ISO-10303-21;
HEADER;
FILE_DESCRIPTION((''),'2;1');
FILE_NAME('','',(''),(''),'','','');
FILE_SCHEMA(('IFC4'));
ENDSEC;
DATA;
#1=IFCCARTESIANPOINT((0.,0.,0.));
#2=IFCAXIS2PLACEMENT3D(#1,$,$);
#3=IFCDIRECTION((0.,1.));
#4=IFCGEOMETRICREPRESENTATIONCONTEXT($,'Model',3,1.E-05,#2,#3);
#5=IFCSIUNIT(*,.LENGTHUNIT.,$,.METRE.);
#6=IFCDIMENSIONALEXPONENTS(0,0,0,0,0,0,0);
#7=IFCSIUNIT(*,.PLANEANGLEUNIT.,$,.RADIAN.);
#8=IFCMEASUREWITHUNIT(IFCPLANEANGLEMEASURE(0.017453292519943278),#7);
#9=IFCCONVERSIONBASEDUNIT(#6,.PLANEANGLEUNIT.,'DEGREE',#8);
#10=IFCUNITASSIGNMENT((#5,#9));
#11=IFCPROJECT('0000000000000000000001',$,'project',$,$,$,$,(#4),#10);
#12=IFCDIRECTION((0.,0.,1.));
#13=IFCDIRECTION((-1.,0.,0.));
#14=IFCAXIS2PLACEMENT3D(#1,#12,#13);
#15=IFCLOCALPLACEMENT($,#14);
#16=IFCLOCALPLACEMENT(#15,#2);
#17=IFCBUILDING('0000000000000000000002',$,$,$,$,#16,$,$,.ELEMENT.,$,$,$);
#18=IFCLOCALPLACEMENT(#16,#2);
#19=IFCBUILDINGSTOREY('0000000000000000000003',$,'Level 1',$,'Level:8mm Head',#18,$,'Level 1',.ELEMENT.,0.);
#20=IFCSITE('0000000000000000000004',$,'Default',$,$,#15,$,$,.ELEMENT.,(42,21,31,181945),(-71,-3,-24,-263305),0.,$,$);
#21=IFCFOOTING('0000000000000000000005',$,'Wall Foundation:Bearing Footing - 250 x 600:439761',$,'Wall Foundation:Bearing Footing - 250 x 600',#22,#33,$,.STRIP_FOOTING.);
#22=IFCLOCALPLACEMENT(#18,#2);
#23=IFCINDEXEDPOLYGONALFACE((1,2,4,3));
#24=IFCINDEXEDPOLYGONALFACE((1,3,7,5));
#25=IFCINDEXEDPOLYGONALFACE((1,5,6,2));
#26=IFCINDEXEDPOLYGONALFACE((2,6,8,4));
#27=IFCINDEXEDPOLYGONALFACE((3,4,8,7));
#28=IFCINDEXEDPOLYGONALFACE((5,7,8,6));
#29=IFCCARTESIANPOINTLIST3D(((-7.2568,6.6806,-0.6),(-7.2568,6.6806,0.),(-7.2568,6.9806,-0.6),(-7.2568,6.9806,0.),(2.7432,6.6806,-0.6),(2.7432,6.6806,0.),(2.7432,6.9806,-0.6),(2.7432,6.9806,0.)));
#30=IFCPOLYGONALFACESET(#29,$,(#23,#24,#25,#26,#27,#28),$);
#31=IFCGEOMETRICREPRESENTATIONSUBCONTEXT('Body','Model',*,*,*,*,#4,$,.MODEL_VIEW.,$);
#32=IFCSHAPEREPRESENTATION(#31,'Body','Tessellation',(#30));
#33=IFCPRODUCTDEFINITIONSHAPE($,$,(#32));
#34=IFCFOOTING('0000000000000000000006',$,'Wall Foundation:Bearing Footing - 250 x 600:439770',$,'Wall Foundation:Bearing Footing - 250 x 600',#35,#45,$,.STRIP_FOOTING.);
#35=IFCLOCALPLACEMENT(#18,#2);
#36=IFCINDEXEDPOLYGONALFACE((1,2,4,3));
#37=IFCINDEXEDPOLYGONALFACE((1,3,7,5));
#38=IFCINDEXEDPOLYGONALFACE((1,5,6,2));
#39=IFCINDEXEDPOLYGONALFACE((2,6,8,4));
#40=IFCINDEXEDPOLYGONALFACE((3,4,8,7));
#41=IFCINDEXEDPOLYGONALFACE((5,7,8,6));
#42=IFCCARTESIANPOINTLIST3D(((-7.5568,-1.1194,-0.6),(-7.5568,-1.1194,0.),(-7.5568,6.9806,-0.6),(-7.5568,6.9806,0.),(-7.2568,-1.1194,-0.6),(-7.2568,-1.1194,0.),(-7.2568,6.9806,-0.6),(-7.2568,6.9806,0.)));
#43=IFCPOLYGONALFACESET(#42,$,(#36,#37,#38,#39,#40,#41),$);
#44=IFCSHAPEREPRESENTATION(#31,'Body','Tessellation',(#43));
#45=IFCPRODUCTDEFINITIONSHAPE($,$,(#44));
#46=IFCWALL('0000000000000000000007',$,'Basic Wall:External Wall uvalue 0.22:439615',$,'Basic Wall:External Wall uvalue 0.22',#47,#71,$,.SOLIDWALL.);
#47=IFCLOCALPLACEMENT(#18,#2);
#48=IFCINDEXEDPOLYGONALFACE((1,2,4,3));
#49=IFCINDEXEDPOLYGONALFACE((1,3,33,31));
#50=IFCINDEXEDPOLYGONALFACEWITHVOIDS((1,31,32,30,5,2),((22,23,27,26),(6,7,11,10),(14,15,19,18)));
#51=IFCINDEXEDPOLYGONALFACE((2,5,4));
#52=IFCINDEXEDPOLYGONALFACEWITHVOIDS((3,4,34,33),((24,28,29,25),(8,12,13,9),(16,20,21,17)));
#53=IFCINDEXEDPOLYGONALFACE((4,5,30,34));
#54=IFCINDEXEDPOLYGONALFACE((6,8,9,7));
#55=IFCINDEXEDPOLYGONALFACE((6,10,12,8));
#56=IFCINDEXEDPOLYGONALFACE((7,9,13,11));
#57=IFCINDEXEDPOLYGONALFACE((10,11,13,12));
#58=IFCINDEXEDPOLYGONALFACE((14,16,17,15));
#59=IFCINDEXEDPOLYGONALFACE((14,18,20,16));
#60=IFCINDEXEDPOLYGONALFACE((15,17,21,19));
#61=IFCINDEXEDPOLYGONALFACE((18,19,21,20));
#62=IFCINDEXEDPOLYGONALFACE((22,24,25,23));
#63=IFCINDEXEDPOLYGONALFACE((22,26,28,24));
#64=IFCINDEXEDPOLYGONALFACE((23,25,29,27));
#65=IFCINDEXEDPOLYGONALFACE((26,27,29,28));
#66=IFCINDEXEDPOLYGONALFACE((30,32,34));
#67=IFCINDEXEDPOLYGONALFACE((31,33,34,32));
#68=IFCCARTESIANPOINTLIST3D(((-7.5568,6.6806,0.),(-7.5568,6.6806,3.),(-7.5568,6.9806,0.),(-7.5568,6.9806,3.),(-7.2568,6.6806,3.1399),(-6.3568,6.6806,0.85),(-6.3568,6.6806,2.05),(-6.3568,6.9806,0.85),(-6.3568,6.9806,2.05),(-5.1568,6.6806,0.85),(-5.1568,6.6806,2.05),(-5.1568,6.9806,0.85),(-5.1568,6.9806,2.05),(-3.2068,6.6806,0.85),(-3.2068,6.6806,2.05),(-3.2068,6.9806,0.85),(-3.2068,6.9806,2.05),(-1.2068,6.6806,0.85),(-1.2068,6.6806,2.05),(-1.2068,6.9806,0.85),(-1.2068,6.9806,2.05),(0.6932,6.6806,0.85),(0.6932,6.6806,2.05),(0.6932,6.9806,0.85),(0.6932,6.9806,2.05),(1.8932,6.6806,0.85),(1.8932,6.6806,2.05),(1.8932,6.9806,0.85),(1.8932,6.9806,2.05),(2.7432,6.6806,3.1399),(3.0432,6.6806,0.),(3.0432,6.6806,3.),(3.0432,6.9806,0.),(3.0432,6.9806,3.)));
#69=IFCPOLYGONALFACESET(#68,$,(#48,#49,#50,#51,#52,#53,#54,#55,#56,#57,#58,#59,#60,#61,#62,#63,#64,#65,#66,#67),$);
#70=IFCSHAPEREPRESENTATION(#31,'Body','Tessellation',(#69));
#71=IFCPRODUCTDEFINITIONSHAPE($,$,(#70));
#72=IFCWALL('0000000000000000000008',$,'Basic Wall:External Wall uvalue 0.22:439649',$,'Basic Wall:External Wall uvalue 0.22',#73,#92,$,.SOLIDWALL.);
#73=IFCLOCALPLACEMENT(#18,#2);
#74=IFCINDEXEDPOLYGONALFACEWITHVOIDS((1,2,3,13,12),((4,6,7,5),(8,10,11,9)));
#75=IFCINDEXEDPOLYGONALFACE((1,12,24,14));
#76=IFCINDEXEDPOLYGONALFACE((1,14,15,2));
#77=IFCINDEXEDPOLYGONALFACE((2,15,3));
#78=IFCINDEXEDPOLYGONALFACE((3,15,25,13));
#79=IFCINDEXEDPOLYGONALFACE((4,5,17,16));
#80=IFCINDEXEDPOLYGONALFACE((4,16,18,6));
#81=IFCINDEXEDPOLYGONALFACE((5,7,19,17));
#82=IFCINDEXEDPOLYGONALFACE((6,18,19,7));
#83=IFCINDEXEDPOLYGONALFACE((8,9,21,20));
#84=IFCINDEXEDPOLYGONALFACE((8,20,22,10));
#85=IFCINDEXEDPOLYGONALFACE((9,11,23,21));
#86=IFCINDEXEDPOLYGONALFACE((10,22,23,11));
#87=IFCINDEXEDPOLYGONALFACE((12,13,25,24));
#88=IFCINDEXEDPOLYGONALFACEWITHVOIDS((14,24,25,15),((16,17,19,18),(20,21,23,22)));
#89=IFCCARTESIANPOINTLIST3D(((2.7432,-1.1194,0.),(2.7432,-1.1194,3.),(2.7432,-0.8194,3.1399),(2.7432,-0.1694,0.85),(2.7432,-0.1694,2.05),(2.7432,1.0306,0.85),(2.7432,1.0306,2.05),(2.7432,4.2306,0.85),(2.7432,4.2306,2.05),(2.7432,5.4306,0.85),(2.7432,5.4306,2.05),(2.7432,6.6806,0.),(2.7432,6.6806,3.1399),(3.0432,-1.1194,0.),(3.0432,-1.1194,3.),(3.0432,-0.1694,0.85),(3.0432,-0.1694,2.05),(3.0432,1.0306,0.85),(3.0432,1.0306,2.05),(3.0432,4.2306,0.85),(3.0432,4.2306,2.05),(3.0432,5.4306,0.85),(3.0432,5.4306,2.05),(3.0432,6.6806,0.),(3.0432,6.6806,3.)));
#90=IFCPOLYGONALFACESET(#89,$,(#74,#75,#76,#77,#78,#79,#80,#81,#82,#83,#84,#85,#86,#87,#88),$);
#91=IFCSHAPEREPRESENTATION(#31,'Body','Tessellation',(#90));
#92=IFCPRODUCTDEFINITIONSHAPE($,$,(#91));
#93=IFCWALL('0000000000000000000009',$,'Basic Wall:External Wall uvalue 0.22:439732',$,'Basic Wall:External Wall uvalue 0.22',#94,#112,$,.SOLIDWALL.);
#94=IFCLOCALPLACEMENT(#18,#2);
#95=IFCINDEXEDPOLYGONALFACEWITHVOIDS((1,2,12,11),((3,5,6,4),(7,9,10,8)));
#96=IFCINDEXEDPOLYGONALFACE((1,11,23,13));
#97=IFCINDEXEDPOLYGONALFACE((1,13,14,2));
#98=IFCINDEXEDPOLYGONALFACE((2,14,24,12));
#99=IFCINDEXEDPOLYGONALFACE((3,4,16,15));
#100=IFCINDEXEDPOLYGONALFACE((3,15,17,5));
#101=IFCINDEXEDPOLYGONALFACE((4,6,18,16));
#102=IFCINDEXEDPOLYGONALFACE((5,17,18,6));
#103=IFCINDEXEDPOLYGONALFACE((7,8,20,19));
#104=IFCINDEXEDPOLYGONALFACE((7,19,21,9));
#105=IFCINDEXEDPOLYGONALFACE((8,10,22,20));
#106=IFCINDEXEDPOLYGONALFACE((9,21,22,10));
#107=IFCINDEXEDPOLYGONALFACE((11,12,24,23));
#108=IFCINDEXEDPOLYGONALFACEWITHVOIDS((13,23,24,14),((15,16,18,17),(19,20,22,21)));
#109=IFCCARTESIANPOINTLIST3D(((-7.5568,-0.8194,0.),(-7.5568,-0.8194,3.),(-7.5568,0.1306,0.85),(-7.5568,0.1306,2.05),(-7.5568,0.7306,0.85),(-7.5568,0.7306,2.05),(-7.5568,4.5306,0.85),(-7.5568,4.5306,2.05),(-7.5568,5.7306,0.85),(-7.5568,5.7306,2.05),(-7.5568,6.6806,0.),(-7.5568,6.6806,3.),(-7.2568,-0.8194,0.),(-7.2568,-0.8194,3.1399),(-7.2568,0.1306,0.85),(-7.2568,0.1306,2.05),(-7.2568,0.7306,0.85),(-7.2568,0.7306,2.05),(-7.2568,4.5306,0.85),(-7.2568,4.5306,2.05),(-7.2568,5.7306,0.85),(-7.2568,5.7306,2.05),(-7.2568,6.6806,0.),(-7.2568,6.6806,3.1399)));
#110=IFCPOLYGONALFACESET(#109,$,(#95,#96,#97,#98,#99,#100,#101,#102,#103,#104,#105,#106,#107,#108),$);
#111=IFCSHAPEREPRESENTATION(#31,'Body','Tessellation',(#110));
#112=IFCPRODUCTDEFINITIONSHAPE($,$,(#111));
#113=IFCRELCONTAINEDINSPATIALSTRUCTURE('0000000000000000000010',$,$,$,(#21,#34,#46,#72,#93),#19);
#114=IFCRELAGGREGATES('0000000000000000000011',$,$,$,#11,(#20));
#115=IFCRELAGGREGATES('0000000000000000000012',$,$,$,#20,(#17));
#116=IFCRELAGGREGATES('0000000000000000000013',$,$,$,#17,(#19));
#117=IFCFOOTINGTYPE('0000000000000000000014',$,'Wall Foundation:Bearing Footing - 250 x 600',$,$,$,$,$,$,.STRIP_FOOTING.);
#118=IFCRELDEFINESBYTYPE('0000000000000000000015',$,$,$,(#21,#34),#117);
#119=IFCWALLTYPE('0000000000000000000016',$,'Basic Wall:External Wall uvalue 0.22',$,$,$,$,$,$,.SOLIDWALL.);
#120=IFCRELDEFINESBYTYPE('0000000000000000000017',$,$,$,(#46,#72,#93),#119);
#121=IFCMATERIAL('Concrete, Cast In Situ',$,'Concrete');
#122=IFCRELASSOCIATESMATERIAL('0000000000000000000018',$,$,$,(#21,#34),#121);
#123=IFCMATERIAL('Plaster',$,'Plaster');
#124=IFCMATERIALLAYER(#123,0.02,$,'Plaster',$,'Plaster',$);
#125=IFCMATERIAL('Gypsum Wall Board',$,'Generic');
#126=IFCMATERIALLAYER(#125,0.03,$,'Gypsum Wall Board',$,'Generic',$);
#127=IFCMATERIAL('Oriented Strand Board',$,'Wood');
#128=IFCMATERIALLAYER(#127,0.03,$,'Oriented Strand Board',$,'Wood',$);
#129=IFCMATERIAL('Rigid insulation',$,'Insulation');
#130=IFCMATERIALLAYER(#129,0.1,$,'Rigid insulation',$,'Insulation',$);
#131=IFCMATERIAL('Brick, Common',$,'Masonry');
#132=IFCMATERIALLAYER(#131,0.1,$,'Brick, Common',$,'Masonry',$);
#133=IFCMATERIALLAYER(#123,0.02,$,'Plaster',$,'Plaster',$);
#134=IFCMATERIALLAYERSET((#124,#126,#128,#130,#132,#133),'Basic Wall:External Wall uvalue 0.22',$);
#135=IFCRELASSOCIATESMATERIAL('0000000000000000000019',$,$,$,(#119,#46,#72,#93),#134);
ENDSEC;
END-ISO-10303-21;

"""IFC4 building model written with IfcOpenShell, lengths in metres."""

from ifc_helpers import new_model, entity, si_unit, converted_unit, direction, frame, frame_2d, origin, place, context, subcontext, project, spatial, polyline, rectangle, extrude, clip, bounded_halfspace, material, layer, layer_set, layer_usage, type_object, element, save


model = new_model("IFC4")

# Units and contexts
model_context = context("Model", 3, precision=1e-05, world=origin(), true_north=direction((0.0, 1.0)))
body_context = subcontext(model_context, "Body", "Model", "MODEL_VIEW")
ifc_project = project(units=[si_unit("LENGTHUNIT", "METRE"), converted_unit("PLANEANGLEUNIT", "DEGREE", entity("IfcPlaneAngleMeasure", 0.017453292519943278), si_unit("PLANEANGLEUNIT", "RADIAN"), dimensions=[0, 0, 0, 0, 0, 0, 0])], contexts=[model_context])

# Site, building, storey
site_placement = place(None, frame((0.0, 0.0, 0.0), z_axis=(0.0, 0.0, 1.0), x_axis=(-1.0, 0.0, 0.0)))
site = spatial("IfcSite", under=ifc_project, at=site_placement, Name="Default", CompositionType="ELEMENT", RefLatitude=(42, 21, 31, 181945), RefLongitude=(-71, -3, -24, -263305), RefElevation=0.0)
building_placement = place(site_placement, origin())
building = spatial("IfcBuilding", under=site, at=building_placement, CompositionType="ELEMENT")
storey_placement = place(building_placement, origin())
storey = spatial("IfcBuildingStorey", under=building, at=storey_placement, Name="Level 1", ObjectType="Level:8mm Head", LongName="Level 1", CompositionType="ELEMENT", Elevation=0.0)

# Footings
ifc_material_1 = material(Name="Concrete, Cast In Situ", Category="Concrete")
footing_type = type_object("IfcFootingType", Name="Wall Foundation:Bearing Footing - 250 x 600", PredefinedType="STRIP_FOOTING")
footing_1_placement = place(storey_placement, frame((-7.2568, 6.6806, -0.6)))
element("IfcFooting", 1, at=footing_1_placement, inside=storey, type_object=footing_type, material=ifc_material_1, Name="Wall Foundation:Bearing Footing - 250 x 600:439761", ObjectType="Wall Foundation:Bearing Footing - 250 x 600", PredefinedType="STRIP_FOOTING", context=body_context, shape_type="SweptSolid", body=[
    extrude(rectangle(XDim=10.0, YDim=0.3, at=frame_2d((0.0, 0.0), x_axis=(1.0, 0.0))), frame((5.0, 0.15, 0.0)), (0.0, 0.0, 1.0), 0.6),
])
footing_2_placement = place(storey_placement, frame((-7.5568, -1.1194, -0.6)))
element("IfcFooting", 2, at=footing_2_placement, inside=storey, type_object=footing_type, material=ifc_material_1, Name="Wall Foundation:Bearing Footing - 250 x 600:439770", ObjectType="Wall Foundation:Bearing Footing - 250 x 600", PredefinedType="STRIP_FOOTING", context=body_context, shape_type="SweptSolid", body=[
    extrude(rectangle(XDim=8.1, YDim=0.3, at=frame_2d((0.0, 0.05), x_axis=(1.0, 0.0))), frame((0.2, 4.05, 0.0), z_axis=(0.0, 0.0, 1.0), x_axis=(0.0, 1.0, 0.0)), (0.0, 0.0, 1.0), 0.6),
])

# Walls, openings
ifc_material_2 = material(Name="Plaster", Category="Plaster")
ifc_layer_1 = layer(ifc_material_2, 0.02, Name="Plaster", Category="Plaster")
ifc_material_3 = material(Name="Gypsum Wall Board", Category="Generic")
ifc_layer_2 = layer(ifc_material_3, 0.03, Name="Gypsum Wall Board", Category="Generic")
ifc_material_4 = material(Name="Oriented Strand Board", Category="Wood")
ifc_layer_3 = layer(ifc_material_4, 0.03, Name="Oriented Strand Board", Category="Wood")
ifc_material_5 = material(Name="Rigid insulation", Category="Insulation")
ifc_layer_4 = layer(ifc_material_5, 0.1, Name="Rigid insulation", Category="Insulation")
ifc_material_6 = material(Name="Brick, Common", Category="Masonry")
ifc_layer_5 = layer(ifc_material_6, 0.1, Name="Brick, Common", Category="Masonry")
ifc_layer_6 = layer(ifc_material_2, 0.02, Name="Plaster", Category="Plaster")
ifc_layer_set_1 = layer_set([ifc_layer_1, ifc_layer_2, ifc_layer_3, ifc_layer_4, ifc_layer_5, ifc_layer_6], Name="Basic Wall:External Wall uvalue 0.22")
ifc_layer_usage_1 = layer_usage(ifc_layer_set_1, "AXIS2", "NEGATIVE", 0.15)
wall_type_1 = type_object("IfcWallType", Name="Basic Wall:External Wall uvalue 0.22", PredefinedType="SOLIDWALL", material=ifc_layer_set_1)
wall_1_placement = place(storey_placement, frame((-7.5568, 6.8306, 0.0)))
wall_1 = element("IfcWall", 3, at=wall_1_placement, inside=storey, type_object=wall_type_1, material=ifc_layer_usage_1, Name="Basic Wall:External Wall uvalue 0.22:439615", ObjectType="Basic Wall:External Wall uvalue 0.22", PredefinedType="SOLIDWALL", context=body_context, shape_type="Clipping", body=[
    clip(clip(clip(extrude(rectangle(XDim=10.6, YDim=0.3, at=frame_2d((5.3, 0.0), x_axis=(-1.0, 0.0))), origin(), (0.0, 0.0, 1.0), 3.1399), bounded_halfspace(frame((0.3, -0.15, 3.1399), z_axis=(0.0, 0.422618, 0.906308), x_axis=(-1.0, 0.0, 0.0)), False, frame((0.3, -0.15, 3.1399)), polyline([(0.0, 0.0), (10.0, 0.0), (10.3, 0.3), (-0.3, 0.3), (0.0, 0.0)]))), bounded_halfspace(frame((0.0, -0.15, 3.0), z_axis=(-0.422618, 0.0, 0.906308), x_axis=(0.0, -1.0, 0.0)), False, frame((0.0, -0.15, 3.0)), polyline([(0.0, 0.0), (0.3, 0.0), (0.0, 0.3), (0.0, 0.0)]))), bounded_halfspace(frame((10.3, -0.15, 3.1399), z_axis=(0.422618, 0.0, 0.906308), x_axis=(0.0, 1.0, 0.0)), False, frame((10.3, -0.15, 3.1399)), polyline([(0.0, 0.0), (0.3, 0.0), (0.3, 0.3), (0.0, 0.0)]))),
])
opening_1_placement = place(wall_1_placement, frame((1.2, -0.15, 0.85)))
element("IfcOpeningElement", 4, at=opening_1_placement, cuts=wall_1, PredefinedType="OPENING", context=body_context, shape_type="SweptSolid", body=[
    extrude(rectangle(XDim=1.2, YDim=1.2, at=frame_2d((0.6, 0.6), x_axis=(1.0, 0.0))), frame((0.0, 0.0, 0.0), z_axis=(0.0, 1.0, 0.0), x_axis=(0.0, 0.0, 1.0)), (0.0, 0.0, 1.0), 0.3),
])
opening_2_placement = place(wall_1_placement, frame((8.25, -0.15, 0.85)))
element("IfcOpeningElement", 5, at=opening_2_placement, cuts=wall_1, PredefinedType="OPENING", context=body_context, shape_type="SweptSolid", body=[
    extrude(rectangle(XDim=1.2, YDim=1.2, at=frame_2d((0.6, 0.6), x_axis=(1.0, 0.0))), frame((0.0, 0.0, 0.0), z_axis=(0.0, 1.0, 0.0), x_axis=(0.0, 0.0, 1.0)), (0.0, 0.0, 1.0), 0.3),
])
opening_3_placement = place(wall_1_placement, frame((4.35, -0.15, 0.85)))
element("IfcOpeningElement", 6, at=opening_3_placement, cuts=wall_1, PredefinedType="OPENING", context=body_context, shape_type="SweptSolid", body=[
    extrude(rectangle(XDim=1.2, YDim=2.0, at=frame_2d((0.6, 1.0), x_axis=(1.0, 0.0))), frame((0.0, 0.0, 0.0), z_axis=(0.0, 1.0, 0.0), x_axis=(0.0, 0.0, 1.0)), (0.0, 0.0, 1.0), 0.3),
])
wall_2_placement = place(storey_placement, frame((2.8932, 6.6806, 0.0), z_axis=(0.0, 0.0, 1.0), x_axis=(0.0, -1.0, 0.0)))
wall_2 = element("IfcWall", 7, at=wall_2_placement, inside=storey, type_object=wall_type_1, material=ifc_layer_usage_1, Name="Basic Wall:External Wall uvalue 0.22:439649", ObjectType="Basic Wall:External Wall uvalue 0.22", PredefinedType="SOLIDWALL", context=body_context, shape_type="Clipping", body=[
    clip(clip(extrude(rectangle(XDim=7.8, YDim=0.3, at=frame_2d((3.9, 0.0), x_axis=(-1.0, 0.0))), origin(), (0.0, 0.0, 1.0), 3.1399), bounded_halfspace(frame((7.5, -0.15, 3.1399), z_axis=(0.422618, 0.0, 0.906308), x_axis=(0.0, 1.0, 0.0)), False, frame((7.5, -0.15, 3.1399)), polyline([(0.0, 0.0), (0.3, 0.0), (0.3, 0.3), (0.0, 0.0)]))), bounded_halfspace(frame((0.0, -0.15, 3.1399), z_axis=(0.0, 0.422618, 0.906308), x_axis=(-1.0, 0.0, 0.0)), False, frame((0.0, -0.15, 3.1399)), polyline([(0.0, 0.0), (7.5, 0.0), (7.8, 0.3), (0.0, 0.3), (0.0, 0.0)]))),
])
opening_4_placement = place(wall_2_placement, frame((1.25, -0.15, 0.85)))
element("IfcOpeningElement", 8, at=opening_4_placement, cuts=wall_2, PredefinedType="OPENING", context=body_context, shape_type="SweptSolid", body=[
    extrude(rectangle(XDim=1.2, YDim=1.2, at=frame_2d((0.6, 0.6), x_axis=(1.0, 0.0))), frame((0.0, 0.0, 0.0), z_axis=(0.0, 1.0, 0.0), x_axis=(0.0, 0.0, 1.0)), (0.0, 0.0, 1.0), 0.3),
])
opening_5_placement = place(wall_2_placement, frame((6.85, 0.15, 0.85)))
element("IfcOpeningElement", 9, at=opening_5_placement, cuts=wall_2, PredefinedType="OPENING", context=body_context, shape_type="SweptSolid", body=[
    extrude(rectangle(XDim=1.2, YDim=1.2, at=frame_2d((0.6, 0.6), x_axis=(1.0, 0.0))), frame((0.0, 0.0, 0.0), z_axis=(0.0, -1.0, 0.0), x_axis=(0.0, 0.0, 1.0)), (0.0, 0.0, 1.0), 0.3),
])
wall_3_placement = place(storey_placement, frame((-7.4068, -0.8194, 0.0), z_axis=(0.0, 0.0, 1.0), x_axis=(0.0, 1.0, 0.0)))
wall_3 = element("IfcWall", 10, at=wall_3_placement, inside=storey, type_object=wall_type_1, material=ifc_layer_usage_1, Name="Basic Wall:External Wall uvalue 0.22:439732", ObjectType="Basic Wall:External Wall uvalue 0.22", PredefinedType="SOLIDWALL", context=body_context, shape_type="Clipping", body=[
    clip(extrude(rectangle(XDim=7.5, YDim=0.3, at=frame_2d((3.75, 0.0), x_axis=(-1.0, 0.0))), origin(), (0.0, 0.0, 1.0), 3.1399), bounded_halfspace(frame((0.0, -0.15, 3.1399), z_axis=(0.0, 0.422618, 0.906308), x_axis=(-1.0, 0.0, 0.0)), False, frame((0.0, -0.15, 3.1399)), polyline([(0.0, 0.0), (7.5, 0.0), (7.5, 0.3), (0.0, 0.3), (0.0, 0.0)]))),
])
opening_6_placement = place(wall_3_placement, frame((5.35, -0.15, 0.85)))
element("IfcOpeningElement", 11, at=opening_6_placement, cuts=wall_3, PredefinedType="OPENING", context=body_context, shape_type="SweptSolid", body=[
    extrude(rectangle(XDim=1.2, YDim=1.2, at=frame_2d((0.6, 0.6), x_axis=(1.0, 0.0))), frame((0.0, 0.0, 0.0), z_axis=(0.0, 1.0, 0.0), x_axis=(0.0, 0.0, 1.0)), (0.0, 0.0, 1.0), 0.3),
])
opening_7_placement = place(wall_3_placement, frame((0.95, -0.15, 0.85)))
element("IfcOpeningElement", 12, at=opening_7_placement, cuts=wall_3, PredefinedType="OPENING", context=body_context, shape_type="SweptSolid", body=[
    extrude(rectangle(XDim=1.2, YDim=0.6, at=frame_2d((0.6, 0.3), x_axis=(1.0, 0.0))), frame((0.0, 0.0, 0.0), z_axis=(0.0, 1.0, 0.0), x_axis=(0.0, 0.0, 1.0)), (0.0, 0.0, 1.0), 0.3),
])

save(model, "model.ifc")
